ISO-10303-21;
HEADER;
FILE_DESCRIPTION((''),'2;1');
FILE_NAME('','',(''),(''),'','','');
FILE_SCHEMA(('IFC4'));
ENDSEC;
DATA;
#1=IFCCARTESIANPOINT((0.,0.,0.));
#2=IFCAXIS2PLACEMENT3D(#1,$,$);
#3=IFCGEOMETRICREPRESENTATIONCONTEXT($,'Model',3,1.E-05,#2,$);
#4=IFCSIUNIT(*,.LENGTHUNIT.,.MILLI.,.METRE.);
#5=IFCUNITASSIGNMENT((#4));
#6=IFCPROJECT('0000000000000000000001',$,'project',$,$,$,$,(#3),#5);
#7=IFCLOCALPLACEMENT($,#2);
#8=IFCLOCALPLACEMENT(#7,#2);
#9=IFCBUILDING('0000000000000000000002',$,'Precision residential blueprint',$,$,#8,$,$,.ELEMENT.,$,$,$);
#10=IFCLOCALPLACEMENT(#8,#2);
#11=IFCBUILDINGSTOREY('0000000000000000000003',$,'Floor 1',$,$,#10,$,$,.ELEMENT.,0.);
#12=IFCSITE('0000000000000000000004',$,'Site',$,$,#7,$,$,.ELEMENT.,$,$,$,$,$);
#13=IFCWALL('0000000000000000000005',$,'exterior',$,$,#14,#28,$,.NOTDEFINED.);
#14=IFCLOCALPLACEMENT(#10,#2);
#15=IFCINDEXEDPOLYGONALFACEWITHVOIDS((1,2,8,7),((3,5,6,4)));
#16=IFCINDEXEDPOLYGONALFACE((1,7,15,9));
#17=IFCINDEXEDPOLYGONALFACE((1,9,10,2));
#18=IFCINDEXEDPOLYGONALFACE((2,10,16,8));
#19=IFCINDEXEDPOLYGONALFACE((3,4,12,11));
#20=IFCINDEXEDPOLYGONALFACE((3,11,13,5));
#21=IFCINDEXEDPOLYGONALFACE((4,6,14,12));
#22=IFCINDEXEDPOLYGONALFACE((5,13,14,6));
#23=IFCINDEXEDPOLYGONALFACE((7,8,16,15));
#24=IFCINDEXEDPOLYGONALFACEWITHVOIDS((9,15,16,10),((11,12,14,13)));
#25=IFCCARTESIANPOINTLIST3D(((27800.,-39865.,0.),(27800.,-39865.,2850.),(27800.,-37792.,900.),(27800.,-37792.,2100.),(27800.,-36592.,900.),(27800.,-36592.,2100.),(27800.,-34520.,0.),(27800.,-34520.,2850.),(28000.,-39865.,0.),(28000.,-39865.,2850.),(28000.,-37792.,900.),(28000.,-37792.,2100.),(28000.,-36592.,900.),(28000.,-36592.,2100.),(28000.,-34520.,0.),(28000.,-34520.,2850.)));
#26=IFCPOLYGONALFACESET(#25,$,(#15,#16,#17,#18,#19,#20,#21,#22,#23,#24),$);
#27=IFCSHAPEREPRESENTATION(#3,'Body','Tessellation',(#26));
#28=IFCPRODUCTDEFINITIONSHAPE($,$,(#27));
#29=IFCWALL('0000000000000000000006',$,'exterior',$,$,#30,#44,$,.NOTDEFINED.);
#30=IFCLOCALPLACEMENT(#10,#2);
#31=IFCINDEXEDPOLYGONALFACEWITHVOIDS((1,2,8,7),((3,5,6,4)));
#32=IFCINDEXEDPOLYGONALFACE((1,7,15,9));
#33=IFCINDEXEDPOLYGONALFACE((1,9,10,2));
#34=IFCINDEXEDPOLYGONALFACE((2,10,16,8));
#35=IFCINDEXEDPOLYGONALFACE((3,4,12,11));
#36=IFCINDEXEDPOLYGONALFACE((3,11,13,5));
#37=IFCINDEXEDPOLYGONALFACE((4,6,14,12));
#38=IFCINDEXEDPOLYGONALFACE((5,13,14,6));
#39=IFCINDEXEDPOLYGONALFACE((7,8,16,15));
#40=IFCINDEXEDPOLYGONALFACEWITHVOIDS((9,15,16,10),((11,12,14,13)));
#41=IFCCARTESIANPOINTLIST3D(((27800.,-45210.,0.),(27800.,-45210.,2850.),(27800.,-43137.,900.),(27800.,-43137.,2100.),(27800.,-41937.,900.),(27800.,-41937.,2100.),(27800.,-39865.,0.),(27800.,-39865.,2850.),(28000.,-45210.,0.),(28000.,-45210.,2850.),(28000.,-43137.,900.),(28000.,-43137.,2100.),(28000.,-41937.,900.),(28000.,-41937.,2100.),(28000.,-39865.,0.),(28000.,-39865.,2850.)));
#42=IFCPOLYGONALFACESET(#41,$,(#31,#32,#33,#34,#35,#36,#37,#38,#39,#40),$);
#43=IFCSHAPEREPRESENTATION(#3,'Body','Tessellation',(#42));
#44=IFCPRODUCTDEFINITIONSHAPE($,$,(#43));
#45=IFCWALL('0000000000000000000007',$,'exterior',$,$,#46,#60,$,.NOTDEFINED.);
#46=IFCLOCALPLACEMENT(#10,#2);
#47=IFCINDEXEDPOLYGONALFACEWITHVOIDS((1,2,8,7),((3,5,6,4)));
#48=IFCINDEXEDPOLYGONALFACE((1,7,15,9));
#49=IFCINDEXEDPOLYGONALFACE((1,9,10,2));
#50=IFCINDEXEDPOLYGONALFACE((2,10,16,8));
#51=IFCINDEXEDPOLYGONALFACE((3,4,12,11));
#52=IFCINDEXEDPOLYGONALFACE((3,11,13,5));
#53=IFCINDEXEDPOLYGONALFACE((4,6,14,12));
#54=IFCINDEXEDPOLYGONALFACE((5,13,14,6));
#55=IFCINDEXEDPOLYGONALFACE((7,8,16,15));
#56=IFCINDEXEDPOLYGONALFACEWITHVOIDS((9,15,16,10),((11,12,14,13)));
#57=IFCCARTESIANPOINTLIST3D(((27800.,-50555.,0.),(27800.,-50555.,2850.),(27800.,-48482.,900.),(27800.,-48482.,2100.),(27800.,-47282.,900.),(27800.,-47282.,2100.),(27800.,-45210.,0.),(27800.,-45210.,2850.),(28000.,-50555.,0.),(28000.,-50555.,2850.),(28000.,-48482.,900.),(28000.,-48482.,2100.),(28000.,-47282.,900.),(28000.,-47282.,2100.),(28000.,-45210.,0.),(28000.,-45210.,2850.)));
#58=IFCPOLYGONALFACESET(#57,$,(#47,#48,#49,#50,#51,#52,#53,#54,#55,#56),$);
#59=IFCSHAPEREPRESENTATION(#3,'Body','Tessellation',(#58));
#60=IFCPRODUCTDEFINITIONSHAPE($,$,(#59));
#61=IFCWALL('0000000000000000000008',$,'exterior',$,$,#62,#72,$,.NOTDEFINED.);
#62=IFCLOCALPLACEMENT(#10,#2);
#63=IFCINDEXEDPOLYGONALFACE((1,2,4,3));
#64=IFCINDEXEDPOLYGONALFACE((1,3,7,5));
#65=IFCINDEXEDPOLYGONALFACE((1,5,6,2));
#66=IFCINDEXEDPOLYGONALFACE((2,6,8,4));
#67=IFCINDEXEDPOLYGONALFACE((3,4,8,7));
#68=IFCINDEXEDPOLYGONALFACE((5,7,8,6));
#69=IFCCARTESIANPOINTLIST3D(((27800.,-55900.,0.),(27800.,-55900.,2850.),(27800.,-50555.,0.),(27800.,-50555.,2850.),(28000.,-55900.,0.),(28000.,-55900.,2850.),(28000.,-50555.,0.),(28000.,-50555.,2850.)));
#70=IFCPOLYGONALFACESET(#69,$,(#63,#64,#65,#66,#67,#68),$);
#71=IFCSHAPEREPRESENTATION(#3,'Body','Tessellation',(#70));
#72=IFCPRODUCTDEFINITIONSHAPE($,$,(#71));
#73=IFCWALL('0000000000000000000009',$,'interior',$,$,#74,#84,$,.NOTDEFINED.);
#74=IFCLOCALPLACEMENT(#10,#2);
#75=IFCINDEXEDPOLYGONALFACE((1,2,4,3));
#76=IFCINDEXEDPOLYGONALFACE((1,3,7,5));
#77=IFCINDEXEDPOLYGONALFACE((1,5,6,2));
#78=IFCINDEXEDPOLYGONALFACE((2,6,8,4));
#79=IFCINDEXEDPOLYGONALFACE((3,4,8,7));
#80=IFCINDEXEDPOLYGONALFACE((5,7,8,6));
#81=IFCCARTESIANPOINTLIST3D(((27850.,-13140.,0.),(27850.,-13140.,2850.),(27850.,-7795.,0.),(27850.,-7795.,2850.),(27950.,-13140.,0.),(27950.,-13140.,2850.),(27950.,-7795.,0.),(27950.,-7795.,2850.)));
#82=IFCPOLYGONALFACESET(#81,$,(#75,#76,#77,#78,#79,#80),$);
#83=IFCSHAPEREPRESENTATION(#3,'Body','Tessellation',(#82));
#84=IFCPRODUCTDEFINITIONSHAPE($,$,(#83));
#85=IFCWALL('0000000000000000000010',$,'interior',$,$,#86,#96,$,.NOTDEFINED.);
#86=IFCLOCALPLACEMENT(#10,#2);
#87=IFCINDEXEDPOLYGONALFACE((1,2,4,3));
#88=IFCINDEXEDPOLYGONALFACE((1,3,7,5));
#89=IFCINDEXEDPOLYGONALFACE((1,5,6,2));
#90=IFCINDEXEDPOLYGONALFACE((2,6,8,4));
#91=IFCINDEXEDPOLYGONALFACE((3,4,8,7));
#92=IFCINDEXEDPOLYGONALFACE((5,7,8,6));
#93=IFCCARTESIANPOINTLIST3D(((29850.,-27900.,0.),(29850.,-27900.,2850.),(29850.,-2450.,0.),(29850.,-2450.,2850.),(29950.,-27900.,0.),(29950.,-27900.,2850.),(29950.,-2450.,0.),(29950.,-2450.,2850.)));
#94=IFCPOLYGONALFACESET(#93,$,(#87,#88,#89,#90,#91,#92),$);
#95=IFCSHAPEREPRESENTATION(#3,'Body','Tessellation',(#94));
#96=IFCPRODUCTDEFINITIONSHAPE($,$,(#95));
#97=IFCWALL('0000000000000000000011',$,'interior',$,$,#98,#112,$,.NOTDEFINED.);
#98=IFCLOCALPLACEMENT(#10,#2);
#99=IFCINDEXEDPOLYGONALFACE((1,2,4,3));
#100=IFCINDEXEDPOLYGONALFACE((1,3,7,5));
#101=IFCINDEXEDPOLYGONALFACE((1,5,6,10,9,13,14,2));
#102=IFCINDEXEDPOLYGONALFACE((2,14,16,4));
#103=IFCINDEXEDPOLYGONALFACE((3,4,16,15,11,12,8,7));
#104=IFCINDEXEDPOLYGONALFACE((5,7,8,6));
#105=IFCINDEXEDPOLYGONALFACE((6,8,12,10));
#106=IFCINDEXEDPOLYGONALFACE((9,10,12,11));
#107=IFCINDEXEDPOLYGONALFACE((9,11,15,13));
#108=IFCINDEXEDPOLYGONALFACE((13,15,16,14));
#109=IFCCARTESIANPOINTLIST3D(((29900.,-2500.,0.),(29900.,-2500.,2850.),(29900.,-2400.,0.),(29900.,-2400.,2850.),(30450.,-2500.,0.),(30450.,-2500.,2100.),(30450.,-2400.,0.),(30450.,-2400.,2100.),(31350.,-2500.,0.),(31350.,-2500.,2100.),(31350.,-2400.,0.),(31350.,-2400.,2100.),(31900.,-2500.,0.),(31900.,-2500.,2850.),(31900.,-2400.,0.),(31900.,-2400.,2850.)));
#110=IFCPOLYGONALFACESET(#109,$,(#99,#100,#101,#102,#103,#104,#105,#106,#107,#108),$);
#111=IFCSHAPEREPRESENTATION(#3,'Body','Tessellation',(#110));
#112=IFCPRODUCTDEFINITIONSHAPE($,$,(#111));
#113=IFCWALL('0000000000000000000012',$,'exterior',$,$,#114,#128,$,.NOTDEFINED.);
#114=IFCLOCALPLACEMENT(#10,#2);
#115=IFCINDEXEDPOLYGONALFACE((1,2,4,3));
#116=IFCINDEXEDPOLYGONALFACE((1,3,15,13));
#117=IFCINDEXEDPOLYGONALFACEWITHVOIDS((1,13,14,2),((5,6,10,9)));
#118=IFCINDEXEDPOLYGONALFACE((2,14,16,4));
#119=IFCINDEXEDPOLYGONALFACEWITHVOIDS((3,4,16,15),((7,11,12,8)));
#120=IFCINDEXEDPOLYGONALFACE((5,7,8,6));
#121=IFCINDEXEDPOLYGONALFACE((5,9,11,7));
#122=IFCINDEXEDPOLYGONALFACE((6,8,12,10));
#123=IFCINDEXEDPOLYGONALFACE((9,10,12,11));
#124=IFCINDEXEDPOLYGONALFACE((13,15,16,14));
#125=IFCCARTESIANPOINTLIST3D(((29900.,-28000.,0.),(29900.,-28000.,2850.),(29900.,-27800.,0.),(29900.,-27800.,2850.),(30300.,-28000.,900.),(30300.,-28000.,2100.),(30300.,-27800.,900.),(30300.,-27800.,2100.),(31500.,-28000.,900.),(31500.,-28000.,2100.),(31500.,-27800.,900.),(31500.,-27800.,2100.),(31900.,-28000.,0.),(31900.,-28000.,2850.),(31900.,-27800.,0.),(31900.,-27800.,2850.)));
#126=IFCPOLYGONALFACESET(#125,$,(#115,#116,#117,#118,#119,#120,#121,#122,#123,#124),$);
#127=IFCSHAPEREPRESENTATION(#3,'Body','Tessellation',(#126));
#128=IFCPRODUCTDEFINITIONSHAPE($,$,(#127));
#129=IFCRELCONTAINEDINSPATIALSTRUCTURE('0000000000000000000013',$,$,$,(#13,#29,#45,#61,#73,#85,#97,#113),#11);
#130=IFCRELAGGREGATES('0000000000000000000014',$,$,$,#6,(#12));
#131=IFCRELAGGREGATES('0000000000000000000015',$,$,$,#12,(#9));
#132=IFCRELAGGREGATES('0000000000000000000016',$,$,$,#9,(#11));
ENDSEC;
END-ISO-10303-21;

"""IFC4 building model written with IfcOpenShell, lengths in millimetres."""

from ifc_helpers import new_model, si_unit, frame, origin, place, context, project, spatial, polyline, outline, extrude, element, save


model = new_model("IFC4")

# Units and contexts
model_context = context("Model", 3, precision=1e-05, world=origin())
ifc_project = project(units=[si_unit("LENGTHUNIT", "METRE", prefix="MILLI")], contexts=[model_context])

# Site, building, storey
site_placement = place(None, origin())
site = spatial("IfcSite", under=ifc_project, at=site_placement, Name="Site", CompositionType="ELEMENT")
building_placement = place(site_placement, origin())
building = spatial("IfcBuilding", under=site, at=building_placement, Name="Precision residential blueprint", CompositionType="ELEMENT")
storey_placement = place(building_placement, origin())
storey = spatial("IfcBuildingStorey", under=building, at=storey_placement, Name="Floor 1", CompositionType="ELEMENT", Elevation=0.0)

# Walls, openings
wall_1_placement = place(storey_placement, origin())
wall_1 = element("IfcWall", 1, at=wall_1_placement, inside=storey, Name="exterior", PredefinedType="NOTDEFINED", context=model_context, shape_type="SweptSolid", body=[
    extrude(outline(polyline([(28000.0, -34520.0), (28000.0, -39865.0), (27800.0, -39865.0), (27800.0, -34520.0), (28000.0, -34520.0)])), origin(), (0.0, 0.0, 1.0), 2850.0),
])
opening_1_placement = place(storey_placement, origin())
element("IfcOpeningElement", 2, at=opening_1_placement, cuts=wall_1, PredefinedType="OPENING", context=model_context, shape_type="SweptSolid", body=[
    extrude(outline(polyline([(28000.0, -36592.0), (28000.0, -37792.0), (27800.0, -37792.0), (27800.0, -36592.0), (28000.0, -36592.0)])), frame((0.0, 0.0, 900.0)), (0.0, 0.0, 1.0), 1200.0),
])
wall_2_placement = place(storey_placement, origin())
wall_2 = element("IfcWall", 3, at=wall_2_placement, inside=storey, Name="exterior", PredefinedType="NOTDEFINED", context=model_context, shape_type="SweptSolid", body=[
    extrude(outline(polyline([(28000.0, -39865.0), (28000.0, -45210.0), (27800.0, -45210.0), (27800.0, -39865.0), (28000.0, -39865.0)])), origin(), (0.0, 0.0, 1.0), 2850.0),
])
opening_2_placement = place(storey_placement, origin())
element("IfcOpeningElement", 4, at=opening_2_placement, cuts=wall_2, PredefinedType="OPENING", context=model_context, shape_type="SweptSolid", body=[
    extrude(outline(polyline([(28000.0, -41937.0), (28000.0, -43137.0), (27800.0, -43137.0), (27800.0, -41937.0), (28000.0, -41937.0)])), frame((0.0, 0.0, 900.0)), (0.0, 0.0, 1.0), 1200.0),
])
wall_3_placement = place(storey_placement, origin())
wall_3 = element("IfcWall", 5, at=wall_3_placement, inside=storey, Name="exterior", PredefinedType="NOTDEFINED", context=model_context, shape_type="SweptSolid", body=[
    extrude(outline(polyline([(28000.0, -45210.0), (28000.0, -50555.0), (27800.0, -50555.0), (27800.0, -45210.0), (28000.0, -45210.0)])), origin(), (0.0, 0.0, 1.0), 2850.0),
])
opening_3_placement = place(storey_placement, origin())
element("IfcOpeningElement", 6, at=opening_3_placement, cuts=wall_3, PredefinedType="OPENING", context=model_context, shape_type="SweptSolid", body=[
    extrude(outline(polyline([(28000.0, -47282.0), (28000.0, -48482.0), (27800.0, -48482.0), (27800.0, -47282.0), (28000.0, -47282.0)])), frame((0.0, 0.0, 900.0)), (0.0, 0.0, 1.0), 1200.0),
])

# Walls
wall_4_placement = place(storey_placement, origin())
element("IfcWall", 7, at=wall_4_placement, inside=storey, Name="exterior", PredefinedType="NOTDEFINED", context=model_context, shape_type="SweptSolid", body=[
    extrude(outline(polyline([(28000.0, -50555.0), (28000.0, -55900.0), (27800.0, -55900.0), (27800.0, -50555.0), (28000.0, -50555.0)])), origin(), (0.0, 0.0, 1.0), 2850.0),
])
wall_5_placement = place(storey_placement, origin())
element("IfcWall", 8, at=wall_5_placement, inside=storey, Name="interior", PredefinedType="NOTDEFINED", context=model_context, shape_type="SweptSolid", body=[
    extrude(outline(polyline([(27950.0, -7795.0), (27950.0, -13140.0), (27850.0, -13140.0), (27850.0, -7795.0), (27950.0, -7795.0)])), origin(), (0.0, 0.0, 1.0), 2850.0),
])
wall_6_placement = place(storey_placement, origin())
element("IfcWall", 9, at=wall_6_placement, inside=storey, Name="interior", PredefinedType="NOTDEFINED", context=model_context, shape_type="SweptSolid", body=[
    extrude(outline(polyline([(29950.0, -2450.0), (29950.0, -27900.0), (29850.0, -27900.0), (29850.0, -2450.0), (29950.0, -2450.0)])), origin(), (0.0, 0.0, 1.0), 2850.0),
])

# Walls, openings
wall_7_placement = place(storey_placement, origin())
wall_7 = element("IfcWall", 10, at=wall_7_placement, inside=storey, Name="interior", PredefinedType="NOTDEFINED", context=model_context, shape_type="SweptSolid", body=[
    extrude(outline(polyline([(29900.0, -2400.0), (31900.0, -2400.0), (31900.0, -2500.0), (29900.0, -2500.0), (29900.0, -2400.0)])), origin(), (0.0, 0.0, 1.0), 2850.0),
])
opening_4_placement = place(storey_placement, origin())
element("IfcOpeningElement", 11, at=opening_4_placement, cuts=wall_7, PredefinedType="OPENING", context=model_context, shape_type="SweptSolid", body=[
    extrude(outline(polyline([(30450.0, -2400.0), (31350.0, -2400.0), (31350.0, -2500.0), (30450.0, -2500.0), (30450.0, -2400.0)])), origin(), (0.0, 0.0, 1.0), 2100.0),
])
wall_8_placement = place(storey_placement, origin())
wall_8 = element("IfcWall", 12, at=wall_8_placement, inside=storey, Name="exterior", PredefinedType="NOTDEFINED", context=model_context, shape_type="SweptSolid", body=[
    extrude(outline(polyline([(29900.0, -27800.0), (31900.0, -27800.0), (31900.0, -28000.0), (29900.0, -28000.0), (29900.0, -27800.0)])), origin(), (0.0, 0.0, 1.0), 2850.0),
])
opening_5_placement = place(storey_placement, origin())
element("IfcOpeningElement", 13, at=opening_5_placement, cuts=wall_8, PredefinedType="OPENING", context=model_context, shape_type="SweptSolid", body=[
    extrude(outline(polyline([(30300.0, -27800.0), (31500.0, -27800.0), (31500.0, -28000.0), (30300.0, -28000.0), (30300.0, -27800.0)])), frame((0.0, 0.0, 900.0)), (0.0, 0.0, 1.0), 1200.0),
])

save(model, "model.ifc")
